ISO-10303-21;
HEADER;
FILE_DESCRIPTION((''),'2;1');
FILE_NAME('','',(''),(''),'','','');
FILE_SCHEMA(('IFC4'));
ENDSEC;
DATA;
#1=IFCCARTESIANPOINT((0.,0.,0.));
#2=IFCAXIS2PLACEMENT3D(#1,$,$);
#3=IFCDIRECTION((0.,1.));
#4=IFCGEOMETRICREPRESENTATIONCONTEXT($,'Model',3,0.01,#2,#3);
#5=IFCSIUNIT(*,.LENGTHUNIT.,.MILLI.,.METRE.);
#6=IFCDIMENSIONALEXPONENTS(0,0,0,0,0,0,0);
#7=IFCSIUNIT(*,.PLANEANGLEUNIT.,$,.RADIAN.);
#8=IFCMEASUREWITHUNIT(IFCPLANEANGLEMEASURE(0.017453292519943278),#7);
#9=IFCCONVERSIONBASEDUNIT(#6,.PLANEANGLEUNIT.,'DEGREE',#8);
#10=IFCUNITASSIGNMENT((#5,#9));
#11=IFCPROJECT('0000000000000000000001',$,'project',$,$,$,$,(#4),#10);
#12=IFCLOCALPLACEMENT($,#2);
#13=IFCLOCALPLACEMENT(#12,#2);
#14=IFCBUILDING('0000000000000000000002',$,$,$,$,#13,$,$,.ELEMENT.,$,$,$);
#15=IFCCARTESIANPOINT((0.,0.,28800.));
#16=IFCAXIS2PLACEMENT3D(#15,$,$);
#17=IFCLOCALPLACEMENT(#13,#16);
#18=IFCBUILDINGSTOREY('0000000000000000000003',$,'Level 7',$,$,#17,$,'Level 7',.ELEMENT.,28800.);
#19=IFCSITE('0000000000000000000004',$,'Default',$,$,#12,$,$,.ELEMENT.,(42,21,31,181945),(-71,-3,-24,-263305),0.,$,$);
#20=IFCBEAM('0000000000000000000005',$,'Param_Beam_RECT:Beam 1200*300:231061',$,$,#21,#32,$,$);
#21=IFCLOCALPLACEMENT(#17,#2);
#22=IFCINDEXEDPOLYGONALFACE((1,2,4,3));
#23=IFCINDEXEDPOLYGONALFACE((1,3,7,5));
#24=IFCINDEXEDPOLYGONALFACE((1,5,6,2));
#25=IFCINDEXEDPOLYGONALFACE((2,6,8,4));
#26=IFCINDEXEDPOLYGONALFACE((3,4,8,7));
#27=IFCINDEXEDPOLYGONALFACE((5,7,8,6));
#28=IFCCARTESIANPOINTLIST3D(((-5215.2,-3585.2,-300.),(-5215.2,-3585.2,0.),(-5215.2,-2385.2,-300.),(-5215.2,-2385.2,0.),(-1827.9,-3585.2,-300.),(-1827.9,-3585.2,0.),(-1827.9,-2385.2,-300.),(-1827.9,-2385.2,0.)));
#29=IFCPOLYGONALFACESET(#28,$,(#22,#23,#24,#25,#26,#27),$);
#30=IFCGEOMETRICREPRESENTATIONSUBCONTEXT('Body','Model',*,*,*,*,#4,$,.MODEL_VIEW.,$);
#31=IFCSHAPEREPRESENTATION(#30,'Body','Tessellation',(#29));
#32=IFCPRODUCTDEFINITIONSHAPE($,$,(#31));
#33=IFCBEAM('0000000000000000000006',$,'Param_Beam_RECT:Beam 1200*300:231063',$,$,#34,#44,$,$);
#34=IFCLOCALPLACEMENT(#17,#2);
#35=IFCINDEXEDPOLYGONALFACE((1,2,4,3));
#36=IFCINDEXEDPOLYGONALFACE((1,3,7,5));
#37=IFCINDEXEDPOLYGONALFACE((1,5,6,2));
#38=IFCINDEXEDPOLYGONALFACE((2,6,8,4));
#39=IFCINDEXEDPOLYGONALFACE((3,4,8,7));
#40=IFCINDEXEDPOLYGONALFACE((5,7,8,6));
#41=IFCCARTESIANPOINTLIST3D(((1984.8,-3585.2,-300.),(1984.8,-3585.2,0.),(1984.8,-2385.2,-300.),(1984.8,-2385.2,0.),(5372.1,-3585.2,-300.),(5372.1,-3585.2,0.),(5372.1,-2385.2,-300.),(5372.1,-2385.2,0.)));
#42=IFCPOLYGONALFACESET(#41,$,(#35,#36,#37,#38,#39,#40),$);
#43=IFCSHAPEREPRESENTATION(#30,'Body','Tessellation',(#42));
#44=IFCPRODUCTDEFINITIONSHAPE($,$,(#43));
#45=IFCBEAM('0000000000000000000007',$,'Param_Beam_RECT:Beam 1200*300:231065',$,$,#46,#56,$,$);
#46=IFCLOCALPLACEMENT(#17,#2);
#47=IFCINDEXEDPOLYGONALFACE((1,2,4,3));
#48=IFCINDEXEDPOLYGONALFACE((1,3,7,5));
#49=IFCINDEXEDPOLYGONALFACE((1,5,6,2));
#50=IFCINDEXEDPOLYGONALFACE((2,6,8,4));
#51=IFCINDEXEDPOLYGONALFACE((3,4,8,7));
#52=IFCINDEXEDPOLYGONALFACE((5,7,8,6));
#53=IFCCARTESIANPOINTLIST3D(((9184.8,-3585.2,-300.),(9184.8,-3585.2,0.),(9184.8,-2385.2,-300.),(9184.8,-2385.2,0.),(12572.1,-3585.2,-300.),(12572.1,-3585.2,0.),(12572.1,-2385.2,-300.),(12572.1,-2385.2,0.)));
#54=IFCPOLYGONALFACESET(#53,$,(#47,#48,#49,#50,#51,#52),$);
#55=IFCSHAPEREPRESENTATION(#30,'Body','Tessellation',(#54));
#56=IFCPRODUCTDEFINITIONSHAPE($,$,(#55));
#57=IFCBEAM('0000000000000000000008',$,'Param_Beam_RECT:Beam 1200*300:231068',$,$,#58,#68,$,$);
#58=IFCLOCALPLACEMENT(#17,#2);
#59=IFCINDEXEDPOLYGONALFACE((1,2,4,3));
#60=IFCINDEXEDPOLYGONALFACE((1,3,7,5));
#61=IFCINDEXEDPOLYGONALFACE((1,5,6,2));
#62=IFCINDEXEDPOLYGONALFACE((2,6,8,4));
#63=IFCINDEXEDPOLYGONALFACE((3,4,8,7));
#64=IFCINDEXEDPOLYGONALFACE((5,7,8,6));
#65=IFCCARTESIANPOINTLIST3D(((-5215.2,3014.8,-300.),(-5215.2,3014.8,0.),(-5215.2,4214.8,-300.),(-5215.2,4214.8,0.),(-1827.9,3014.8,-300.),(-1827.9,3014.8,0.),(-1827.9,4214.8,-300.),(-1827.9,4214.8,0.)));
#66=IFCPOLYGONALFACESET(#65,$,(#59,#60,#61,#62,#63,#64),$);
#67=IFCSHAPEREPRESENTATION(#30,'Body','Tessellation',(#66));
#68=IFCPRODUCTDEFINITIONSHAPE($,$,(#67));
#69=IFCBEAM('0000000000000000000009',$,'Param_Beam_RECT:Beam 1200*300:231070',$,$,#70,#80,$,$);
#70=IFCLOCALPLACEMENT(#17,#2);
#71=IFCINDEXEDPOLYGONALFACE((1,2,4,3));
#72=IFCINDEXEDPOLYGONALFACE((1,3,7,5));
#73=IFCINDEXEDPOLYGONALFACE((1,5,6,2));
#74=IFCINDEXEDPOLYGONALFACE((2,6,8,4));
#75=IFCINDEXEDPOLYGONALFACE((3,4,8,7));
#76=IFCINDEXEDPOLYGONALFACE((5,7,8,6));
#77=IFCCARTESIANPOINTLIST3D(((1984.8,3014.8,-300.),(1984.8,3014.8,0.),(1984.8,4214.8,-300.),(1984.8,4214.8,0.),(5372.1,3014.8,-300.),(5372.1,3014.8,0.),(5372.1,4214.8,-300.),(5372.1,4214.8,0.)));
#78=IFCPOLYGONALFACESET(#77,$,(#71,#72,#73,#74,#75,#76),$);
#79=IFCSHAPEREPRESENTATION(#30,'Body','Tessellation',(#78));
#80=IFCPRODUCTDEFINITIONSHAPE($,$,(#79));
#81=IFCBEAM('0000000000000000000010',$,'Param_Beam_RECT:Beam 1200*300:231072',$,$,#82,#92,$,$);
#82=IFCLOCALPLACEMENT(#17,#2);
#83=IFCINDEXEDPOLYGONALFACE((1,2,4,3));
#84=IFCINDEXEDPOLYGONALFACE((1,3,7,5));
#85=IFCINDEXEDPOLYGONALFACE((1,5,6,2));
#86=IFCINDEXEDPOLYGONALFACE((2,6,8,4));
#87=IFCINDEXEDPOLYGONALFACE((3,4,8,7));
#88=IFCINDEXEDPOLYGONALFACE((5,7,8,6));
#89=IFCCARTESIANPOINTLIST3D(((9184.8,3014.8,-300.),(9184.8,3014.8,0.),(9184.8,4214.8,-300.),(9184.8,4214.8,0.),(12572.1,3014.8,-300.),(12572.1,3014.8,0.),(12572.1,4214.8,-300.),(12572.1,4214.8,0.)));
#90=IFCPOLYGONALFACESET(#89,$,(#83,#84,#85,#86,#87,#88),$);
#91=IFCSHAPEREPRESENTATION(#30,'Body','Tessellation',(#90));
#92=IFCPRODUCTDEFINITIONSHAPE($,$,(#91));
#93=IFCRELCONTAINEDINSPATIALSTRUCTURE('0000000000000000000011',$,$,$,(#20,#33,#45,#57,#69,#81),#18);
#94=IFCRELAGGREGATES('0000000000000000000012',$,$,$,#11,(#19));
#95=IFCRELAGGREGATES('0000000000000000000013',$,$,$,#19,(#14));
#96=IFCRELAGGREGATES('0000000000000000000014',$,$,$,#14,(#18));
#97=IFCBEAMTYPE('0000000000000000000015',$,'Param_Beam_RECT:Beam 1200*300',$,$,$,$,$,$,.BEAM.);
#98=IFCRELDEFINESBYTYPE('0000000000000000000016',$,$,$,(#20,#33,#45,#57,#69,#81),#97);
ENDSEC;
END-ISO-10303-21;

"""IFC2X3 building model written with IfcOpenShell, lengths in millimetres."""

from ifc_helpers import new_model, entity, si_unit, converted_unit, direction, frame, frame_2d, origin, place, context, subcontext, project, spatial, rectangle, extrude, type_object, element, save


model = new_model("IFC2X3")

# Units and contexts
model_context = context("Model", 3, precision=0.01, world=origin(), true_north=direction((0.0, 1.0)))
body_context = subcontext(model_context, "Body", "Model", "MODEL_VIEW")
ifc_project = project(units=[si_unit("LENGTHUNIT", "METRE", prefix="MILLI"), converted_unit("PLANEANGLEUNIT", "DEGREE", entity("IfcPlaneAngleMeasure", 0.017453292519943278), si_unit("PLANEANGLEUNIT", "RADIAN"), dimensions=[0, 0, 0, 0, 0, 0, 0])], contexts=[model_context])

# Site, building, storey
site_placement = place(None, origin())
site = spatial("IfcSite", under=ifc_project, at=site_placement, Name="Default", CompositionType="ELEMENT", RefLatitude=(42, 21, 31, 181945), RefLongitude=(-71, -3, -24, -263305), RefElevation=0.0)
building_placement = place(site_placement, origin())
building = spatial("IfcBuilding", under=site, at=building_placement, CompositionType="ELEMENT")
storey_placement = place(building_placement, frame((0.0, 0.0, 28800.0)))
storey = spatial("IfcBuildingStorey", under=building, at=storey_placement, Name="Level 7", LongName="Level 7", CompositionType="ELEMENT", Elevation=28800.0)

# Beams
beam_type_1 = type_object("IfcBeamType", Name="Param_Beam_RECT:Beam 1200*300", PredefinedType="BEAM")
beam_1_placement = place(storey_placement, frame((-5215.2, -2985.2, 0.0)))
element("IfcBeam", 1, at=beam_1_placement, inside=storey, type_object=beam_type_1, Name="Param_Beam_RECT:Beam 1200*300:231061", context=body_context, shape_type="SweptSolid", body=[
    extrude(rectangle(XDim=300.0, YDim=1200.0, at=frame_2d((0.0, 0.0), x_axis=(1.0, 0.0))), frame((0.0, 0.0, -150.0), z_axis=(1.0, 0.0, 0.0), x_axis=(0.0, 0.0, -1.0)), (0.0, 0.0, 1.0), 3387.3),
])
beam_2_placement = place(storey_placement, frame((1984.8, -2985.2, 0.0)))
element("IfcBeam", 2, at=beam_2_placement, inside=storey, type_object=beam_type_1, Name="Param_Beam_RECT:Beam 1200*300:231063", context=body_context, shape_type="SweptSolid", body=[
    extrude(rectangle(XDim=300.0, YDim=1200.0, at=frame_2d((0.0, 0.0), x_axis=(1.0, 0.0))), frame((0.0, 0.0, -150.0), z_axis=(1.0, 0.0, 0.0), x_axis=(0.0, 0.0, -1.0)), (0.0, 0.0, 1.0), 3387.3),
])
beam_3_placement = place(storey_placement, frame((9184.8, -2985.2, 0.0)))
element("IfcBeam", 3, at=beam_3_placement, inside=storey, type_object=beam_type_1, Name="Param_Beam_RECT:Beam 1200*300:231065", context=body_context, shape_type="SweptSolid", body=[
    extrude(rectangle(XDim=300.0, YDim=1200.0, at=frame_2d((0.0, 0.0), x_axis=(1.0, 0.0))), frame((0.0, 0.0, -150.0), z_axis=(1.0, 0.0, 0.0), x_axis=(0.0, 0.0, -1.0)), (0.0, 0.0, 1.0), 3387.3),
])
beam_4_placement = place(storey_placement, frame((-5215.2, 3614.8, 0.0)))
element("IfcBeam", 4, at=beam_4_placement, inside=storey, type_object=beam_type_1, Name="Param_Beam_RECT:Beam 1200*300:231068", context=body_context, shape_type="SweptSolid", body=[
    extrude(rectangle(XDim=300.0, YDim=1200.0, at=frame_2d((0.0, 0.0), x_axis=(1.0, 0.0))), frame((0.0, 0.0, -150.0), z_axis=(1.0, 0.0, 0.0), x_axis=(0.0, 0.0, -1.0)), (0.0, 0.0, 1.0), 3387.3),
])
beam_5_placement = place(storey_placement, frame((1984.8, 3614.8, 0.0)))
element("IfcBeam", 5, at=beam_5_placement, inside=storey, type_object=beam_type_1, Name="Param_Beam_RECT:Beam 1200*300:231070", context=body_context, shape_type="SweptSolid", body=[
    extrude(rectangle(XDim=300.0, YDim=1200.0, at=frame_2d((0.0, 0.0), x_axis=(1.0, 0.0))), frame((0.0, 0.0, -150.0), z_axis=(1.0, 0.0, 0.0), x_axis=(0.0, 0.0, -1.0)), (0.0, 0.0, 1.0), 3387.3),
])
beam_6_placement = place(storey_placement, frame((9184.8, 3614.8, 0.0)))
element("IfcBeam", 6, at=beam_6_placement, inside=storey, type_object=beam_type_1, Name="Param_Beam_RECT:Beam 1200*300:231072", context=body_context, shape_type="SweptSolid", body=[
    extrude(rectangle(XDim=300.0, YDim=1200.0, at=frame_2d((0.0, 0.0), x_axis=(1.0, 0.0))), frame((0.0, 0.0, -150.0), z_axis=(1.0, 0.0, 0.0), x_axis=(0.0, 0.0, -1.0)), (0.0, 0.0, 1.0), 3387.3),
])

save(model, "model.ifc")
